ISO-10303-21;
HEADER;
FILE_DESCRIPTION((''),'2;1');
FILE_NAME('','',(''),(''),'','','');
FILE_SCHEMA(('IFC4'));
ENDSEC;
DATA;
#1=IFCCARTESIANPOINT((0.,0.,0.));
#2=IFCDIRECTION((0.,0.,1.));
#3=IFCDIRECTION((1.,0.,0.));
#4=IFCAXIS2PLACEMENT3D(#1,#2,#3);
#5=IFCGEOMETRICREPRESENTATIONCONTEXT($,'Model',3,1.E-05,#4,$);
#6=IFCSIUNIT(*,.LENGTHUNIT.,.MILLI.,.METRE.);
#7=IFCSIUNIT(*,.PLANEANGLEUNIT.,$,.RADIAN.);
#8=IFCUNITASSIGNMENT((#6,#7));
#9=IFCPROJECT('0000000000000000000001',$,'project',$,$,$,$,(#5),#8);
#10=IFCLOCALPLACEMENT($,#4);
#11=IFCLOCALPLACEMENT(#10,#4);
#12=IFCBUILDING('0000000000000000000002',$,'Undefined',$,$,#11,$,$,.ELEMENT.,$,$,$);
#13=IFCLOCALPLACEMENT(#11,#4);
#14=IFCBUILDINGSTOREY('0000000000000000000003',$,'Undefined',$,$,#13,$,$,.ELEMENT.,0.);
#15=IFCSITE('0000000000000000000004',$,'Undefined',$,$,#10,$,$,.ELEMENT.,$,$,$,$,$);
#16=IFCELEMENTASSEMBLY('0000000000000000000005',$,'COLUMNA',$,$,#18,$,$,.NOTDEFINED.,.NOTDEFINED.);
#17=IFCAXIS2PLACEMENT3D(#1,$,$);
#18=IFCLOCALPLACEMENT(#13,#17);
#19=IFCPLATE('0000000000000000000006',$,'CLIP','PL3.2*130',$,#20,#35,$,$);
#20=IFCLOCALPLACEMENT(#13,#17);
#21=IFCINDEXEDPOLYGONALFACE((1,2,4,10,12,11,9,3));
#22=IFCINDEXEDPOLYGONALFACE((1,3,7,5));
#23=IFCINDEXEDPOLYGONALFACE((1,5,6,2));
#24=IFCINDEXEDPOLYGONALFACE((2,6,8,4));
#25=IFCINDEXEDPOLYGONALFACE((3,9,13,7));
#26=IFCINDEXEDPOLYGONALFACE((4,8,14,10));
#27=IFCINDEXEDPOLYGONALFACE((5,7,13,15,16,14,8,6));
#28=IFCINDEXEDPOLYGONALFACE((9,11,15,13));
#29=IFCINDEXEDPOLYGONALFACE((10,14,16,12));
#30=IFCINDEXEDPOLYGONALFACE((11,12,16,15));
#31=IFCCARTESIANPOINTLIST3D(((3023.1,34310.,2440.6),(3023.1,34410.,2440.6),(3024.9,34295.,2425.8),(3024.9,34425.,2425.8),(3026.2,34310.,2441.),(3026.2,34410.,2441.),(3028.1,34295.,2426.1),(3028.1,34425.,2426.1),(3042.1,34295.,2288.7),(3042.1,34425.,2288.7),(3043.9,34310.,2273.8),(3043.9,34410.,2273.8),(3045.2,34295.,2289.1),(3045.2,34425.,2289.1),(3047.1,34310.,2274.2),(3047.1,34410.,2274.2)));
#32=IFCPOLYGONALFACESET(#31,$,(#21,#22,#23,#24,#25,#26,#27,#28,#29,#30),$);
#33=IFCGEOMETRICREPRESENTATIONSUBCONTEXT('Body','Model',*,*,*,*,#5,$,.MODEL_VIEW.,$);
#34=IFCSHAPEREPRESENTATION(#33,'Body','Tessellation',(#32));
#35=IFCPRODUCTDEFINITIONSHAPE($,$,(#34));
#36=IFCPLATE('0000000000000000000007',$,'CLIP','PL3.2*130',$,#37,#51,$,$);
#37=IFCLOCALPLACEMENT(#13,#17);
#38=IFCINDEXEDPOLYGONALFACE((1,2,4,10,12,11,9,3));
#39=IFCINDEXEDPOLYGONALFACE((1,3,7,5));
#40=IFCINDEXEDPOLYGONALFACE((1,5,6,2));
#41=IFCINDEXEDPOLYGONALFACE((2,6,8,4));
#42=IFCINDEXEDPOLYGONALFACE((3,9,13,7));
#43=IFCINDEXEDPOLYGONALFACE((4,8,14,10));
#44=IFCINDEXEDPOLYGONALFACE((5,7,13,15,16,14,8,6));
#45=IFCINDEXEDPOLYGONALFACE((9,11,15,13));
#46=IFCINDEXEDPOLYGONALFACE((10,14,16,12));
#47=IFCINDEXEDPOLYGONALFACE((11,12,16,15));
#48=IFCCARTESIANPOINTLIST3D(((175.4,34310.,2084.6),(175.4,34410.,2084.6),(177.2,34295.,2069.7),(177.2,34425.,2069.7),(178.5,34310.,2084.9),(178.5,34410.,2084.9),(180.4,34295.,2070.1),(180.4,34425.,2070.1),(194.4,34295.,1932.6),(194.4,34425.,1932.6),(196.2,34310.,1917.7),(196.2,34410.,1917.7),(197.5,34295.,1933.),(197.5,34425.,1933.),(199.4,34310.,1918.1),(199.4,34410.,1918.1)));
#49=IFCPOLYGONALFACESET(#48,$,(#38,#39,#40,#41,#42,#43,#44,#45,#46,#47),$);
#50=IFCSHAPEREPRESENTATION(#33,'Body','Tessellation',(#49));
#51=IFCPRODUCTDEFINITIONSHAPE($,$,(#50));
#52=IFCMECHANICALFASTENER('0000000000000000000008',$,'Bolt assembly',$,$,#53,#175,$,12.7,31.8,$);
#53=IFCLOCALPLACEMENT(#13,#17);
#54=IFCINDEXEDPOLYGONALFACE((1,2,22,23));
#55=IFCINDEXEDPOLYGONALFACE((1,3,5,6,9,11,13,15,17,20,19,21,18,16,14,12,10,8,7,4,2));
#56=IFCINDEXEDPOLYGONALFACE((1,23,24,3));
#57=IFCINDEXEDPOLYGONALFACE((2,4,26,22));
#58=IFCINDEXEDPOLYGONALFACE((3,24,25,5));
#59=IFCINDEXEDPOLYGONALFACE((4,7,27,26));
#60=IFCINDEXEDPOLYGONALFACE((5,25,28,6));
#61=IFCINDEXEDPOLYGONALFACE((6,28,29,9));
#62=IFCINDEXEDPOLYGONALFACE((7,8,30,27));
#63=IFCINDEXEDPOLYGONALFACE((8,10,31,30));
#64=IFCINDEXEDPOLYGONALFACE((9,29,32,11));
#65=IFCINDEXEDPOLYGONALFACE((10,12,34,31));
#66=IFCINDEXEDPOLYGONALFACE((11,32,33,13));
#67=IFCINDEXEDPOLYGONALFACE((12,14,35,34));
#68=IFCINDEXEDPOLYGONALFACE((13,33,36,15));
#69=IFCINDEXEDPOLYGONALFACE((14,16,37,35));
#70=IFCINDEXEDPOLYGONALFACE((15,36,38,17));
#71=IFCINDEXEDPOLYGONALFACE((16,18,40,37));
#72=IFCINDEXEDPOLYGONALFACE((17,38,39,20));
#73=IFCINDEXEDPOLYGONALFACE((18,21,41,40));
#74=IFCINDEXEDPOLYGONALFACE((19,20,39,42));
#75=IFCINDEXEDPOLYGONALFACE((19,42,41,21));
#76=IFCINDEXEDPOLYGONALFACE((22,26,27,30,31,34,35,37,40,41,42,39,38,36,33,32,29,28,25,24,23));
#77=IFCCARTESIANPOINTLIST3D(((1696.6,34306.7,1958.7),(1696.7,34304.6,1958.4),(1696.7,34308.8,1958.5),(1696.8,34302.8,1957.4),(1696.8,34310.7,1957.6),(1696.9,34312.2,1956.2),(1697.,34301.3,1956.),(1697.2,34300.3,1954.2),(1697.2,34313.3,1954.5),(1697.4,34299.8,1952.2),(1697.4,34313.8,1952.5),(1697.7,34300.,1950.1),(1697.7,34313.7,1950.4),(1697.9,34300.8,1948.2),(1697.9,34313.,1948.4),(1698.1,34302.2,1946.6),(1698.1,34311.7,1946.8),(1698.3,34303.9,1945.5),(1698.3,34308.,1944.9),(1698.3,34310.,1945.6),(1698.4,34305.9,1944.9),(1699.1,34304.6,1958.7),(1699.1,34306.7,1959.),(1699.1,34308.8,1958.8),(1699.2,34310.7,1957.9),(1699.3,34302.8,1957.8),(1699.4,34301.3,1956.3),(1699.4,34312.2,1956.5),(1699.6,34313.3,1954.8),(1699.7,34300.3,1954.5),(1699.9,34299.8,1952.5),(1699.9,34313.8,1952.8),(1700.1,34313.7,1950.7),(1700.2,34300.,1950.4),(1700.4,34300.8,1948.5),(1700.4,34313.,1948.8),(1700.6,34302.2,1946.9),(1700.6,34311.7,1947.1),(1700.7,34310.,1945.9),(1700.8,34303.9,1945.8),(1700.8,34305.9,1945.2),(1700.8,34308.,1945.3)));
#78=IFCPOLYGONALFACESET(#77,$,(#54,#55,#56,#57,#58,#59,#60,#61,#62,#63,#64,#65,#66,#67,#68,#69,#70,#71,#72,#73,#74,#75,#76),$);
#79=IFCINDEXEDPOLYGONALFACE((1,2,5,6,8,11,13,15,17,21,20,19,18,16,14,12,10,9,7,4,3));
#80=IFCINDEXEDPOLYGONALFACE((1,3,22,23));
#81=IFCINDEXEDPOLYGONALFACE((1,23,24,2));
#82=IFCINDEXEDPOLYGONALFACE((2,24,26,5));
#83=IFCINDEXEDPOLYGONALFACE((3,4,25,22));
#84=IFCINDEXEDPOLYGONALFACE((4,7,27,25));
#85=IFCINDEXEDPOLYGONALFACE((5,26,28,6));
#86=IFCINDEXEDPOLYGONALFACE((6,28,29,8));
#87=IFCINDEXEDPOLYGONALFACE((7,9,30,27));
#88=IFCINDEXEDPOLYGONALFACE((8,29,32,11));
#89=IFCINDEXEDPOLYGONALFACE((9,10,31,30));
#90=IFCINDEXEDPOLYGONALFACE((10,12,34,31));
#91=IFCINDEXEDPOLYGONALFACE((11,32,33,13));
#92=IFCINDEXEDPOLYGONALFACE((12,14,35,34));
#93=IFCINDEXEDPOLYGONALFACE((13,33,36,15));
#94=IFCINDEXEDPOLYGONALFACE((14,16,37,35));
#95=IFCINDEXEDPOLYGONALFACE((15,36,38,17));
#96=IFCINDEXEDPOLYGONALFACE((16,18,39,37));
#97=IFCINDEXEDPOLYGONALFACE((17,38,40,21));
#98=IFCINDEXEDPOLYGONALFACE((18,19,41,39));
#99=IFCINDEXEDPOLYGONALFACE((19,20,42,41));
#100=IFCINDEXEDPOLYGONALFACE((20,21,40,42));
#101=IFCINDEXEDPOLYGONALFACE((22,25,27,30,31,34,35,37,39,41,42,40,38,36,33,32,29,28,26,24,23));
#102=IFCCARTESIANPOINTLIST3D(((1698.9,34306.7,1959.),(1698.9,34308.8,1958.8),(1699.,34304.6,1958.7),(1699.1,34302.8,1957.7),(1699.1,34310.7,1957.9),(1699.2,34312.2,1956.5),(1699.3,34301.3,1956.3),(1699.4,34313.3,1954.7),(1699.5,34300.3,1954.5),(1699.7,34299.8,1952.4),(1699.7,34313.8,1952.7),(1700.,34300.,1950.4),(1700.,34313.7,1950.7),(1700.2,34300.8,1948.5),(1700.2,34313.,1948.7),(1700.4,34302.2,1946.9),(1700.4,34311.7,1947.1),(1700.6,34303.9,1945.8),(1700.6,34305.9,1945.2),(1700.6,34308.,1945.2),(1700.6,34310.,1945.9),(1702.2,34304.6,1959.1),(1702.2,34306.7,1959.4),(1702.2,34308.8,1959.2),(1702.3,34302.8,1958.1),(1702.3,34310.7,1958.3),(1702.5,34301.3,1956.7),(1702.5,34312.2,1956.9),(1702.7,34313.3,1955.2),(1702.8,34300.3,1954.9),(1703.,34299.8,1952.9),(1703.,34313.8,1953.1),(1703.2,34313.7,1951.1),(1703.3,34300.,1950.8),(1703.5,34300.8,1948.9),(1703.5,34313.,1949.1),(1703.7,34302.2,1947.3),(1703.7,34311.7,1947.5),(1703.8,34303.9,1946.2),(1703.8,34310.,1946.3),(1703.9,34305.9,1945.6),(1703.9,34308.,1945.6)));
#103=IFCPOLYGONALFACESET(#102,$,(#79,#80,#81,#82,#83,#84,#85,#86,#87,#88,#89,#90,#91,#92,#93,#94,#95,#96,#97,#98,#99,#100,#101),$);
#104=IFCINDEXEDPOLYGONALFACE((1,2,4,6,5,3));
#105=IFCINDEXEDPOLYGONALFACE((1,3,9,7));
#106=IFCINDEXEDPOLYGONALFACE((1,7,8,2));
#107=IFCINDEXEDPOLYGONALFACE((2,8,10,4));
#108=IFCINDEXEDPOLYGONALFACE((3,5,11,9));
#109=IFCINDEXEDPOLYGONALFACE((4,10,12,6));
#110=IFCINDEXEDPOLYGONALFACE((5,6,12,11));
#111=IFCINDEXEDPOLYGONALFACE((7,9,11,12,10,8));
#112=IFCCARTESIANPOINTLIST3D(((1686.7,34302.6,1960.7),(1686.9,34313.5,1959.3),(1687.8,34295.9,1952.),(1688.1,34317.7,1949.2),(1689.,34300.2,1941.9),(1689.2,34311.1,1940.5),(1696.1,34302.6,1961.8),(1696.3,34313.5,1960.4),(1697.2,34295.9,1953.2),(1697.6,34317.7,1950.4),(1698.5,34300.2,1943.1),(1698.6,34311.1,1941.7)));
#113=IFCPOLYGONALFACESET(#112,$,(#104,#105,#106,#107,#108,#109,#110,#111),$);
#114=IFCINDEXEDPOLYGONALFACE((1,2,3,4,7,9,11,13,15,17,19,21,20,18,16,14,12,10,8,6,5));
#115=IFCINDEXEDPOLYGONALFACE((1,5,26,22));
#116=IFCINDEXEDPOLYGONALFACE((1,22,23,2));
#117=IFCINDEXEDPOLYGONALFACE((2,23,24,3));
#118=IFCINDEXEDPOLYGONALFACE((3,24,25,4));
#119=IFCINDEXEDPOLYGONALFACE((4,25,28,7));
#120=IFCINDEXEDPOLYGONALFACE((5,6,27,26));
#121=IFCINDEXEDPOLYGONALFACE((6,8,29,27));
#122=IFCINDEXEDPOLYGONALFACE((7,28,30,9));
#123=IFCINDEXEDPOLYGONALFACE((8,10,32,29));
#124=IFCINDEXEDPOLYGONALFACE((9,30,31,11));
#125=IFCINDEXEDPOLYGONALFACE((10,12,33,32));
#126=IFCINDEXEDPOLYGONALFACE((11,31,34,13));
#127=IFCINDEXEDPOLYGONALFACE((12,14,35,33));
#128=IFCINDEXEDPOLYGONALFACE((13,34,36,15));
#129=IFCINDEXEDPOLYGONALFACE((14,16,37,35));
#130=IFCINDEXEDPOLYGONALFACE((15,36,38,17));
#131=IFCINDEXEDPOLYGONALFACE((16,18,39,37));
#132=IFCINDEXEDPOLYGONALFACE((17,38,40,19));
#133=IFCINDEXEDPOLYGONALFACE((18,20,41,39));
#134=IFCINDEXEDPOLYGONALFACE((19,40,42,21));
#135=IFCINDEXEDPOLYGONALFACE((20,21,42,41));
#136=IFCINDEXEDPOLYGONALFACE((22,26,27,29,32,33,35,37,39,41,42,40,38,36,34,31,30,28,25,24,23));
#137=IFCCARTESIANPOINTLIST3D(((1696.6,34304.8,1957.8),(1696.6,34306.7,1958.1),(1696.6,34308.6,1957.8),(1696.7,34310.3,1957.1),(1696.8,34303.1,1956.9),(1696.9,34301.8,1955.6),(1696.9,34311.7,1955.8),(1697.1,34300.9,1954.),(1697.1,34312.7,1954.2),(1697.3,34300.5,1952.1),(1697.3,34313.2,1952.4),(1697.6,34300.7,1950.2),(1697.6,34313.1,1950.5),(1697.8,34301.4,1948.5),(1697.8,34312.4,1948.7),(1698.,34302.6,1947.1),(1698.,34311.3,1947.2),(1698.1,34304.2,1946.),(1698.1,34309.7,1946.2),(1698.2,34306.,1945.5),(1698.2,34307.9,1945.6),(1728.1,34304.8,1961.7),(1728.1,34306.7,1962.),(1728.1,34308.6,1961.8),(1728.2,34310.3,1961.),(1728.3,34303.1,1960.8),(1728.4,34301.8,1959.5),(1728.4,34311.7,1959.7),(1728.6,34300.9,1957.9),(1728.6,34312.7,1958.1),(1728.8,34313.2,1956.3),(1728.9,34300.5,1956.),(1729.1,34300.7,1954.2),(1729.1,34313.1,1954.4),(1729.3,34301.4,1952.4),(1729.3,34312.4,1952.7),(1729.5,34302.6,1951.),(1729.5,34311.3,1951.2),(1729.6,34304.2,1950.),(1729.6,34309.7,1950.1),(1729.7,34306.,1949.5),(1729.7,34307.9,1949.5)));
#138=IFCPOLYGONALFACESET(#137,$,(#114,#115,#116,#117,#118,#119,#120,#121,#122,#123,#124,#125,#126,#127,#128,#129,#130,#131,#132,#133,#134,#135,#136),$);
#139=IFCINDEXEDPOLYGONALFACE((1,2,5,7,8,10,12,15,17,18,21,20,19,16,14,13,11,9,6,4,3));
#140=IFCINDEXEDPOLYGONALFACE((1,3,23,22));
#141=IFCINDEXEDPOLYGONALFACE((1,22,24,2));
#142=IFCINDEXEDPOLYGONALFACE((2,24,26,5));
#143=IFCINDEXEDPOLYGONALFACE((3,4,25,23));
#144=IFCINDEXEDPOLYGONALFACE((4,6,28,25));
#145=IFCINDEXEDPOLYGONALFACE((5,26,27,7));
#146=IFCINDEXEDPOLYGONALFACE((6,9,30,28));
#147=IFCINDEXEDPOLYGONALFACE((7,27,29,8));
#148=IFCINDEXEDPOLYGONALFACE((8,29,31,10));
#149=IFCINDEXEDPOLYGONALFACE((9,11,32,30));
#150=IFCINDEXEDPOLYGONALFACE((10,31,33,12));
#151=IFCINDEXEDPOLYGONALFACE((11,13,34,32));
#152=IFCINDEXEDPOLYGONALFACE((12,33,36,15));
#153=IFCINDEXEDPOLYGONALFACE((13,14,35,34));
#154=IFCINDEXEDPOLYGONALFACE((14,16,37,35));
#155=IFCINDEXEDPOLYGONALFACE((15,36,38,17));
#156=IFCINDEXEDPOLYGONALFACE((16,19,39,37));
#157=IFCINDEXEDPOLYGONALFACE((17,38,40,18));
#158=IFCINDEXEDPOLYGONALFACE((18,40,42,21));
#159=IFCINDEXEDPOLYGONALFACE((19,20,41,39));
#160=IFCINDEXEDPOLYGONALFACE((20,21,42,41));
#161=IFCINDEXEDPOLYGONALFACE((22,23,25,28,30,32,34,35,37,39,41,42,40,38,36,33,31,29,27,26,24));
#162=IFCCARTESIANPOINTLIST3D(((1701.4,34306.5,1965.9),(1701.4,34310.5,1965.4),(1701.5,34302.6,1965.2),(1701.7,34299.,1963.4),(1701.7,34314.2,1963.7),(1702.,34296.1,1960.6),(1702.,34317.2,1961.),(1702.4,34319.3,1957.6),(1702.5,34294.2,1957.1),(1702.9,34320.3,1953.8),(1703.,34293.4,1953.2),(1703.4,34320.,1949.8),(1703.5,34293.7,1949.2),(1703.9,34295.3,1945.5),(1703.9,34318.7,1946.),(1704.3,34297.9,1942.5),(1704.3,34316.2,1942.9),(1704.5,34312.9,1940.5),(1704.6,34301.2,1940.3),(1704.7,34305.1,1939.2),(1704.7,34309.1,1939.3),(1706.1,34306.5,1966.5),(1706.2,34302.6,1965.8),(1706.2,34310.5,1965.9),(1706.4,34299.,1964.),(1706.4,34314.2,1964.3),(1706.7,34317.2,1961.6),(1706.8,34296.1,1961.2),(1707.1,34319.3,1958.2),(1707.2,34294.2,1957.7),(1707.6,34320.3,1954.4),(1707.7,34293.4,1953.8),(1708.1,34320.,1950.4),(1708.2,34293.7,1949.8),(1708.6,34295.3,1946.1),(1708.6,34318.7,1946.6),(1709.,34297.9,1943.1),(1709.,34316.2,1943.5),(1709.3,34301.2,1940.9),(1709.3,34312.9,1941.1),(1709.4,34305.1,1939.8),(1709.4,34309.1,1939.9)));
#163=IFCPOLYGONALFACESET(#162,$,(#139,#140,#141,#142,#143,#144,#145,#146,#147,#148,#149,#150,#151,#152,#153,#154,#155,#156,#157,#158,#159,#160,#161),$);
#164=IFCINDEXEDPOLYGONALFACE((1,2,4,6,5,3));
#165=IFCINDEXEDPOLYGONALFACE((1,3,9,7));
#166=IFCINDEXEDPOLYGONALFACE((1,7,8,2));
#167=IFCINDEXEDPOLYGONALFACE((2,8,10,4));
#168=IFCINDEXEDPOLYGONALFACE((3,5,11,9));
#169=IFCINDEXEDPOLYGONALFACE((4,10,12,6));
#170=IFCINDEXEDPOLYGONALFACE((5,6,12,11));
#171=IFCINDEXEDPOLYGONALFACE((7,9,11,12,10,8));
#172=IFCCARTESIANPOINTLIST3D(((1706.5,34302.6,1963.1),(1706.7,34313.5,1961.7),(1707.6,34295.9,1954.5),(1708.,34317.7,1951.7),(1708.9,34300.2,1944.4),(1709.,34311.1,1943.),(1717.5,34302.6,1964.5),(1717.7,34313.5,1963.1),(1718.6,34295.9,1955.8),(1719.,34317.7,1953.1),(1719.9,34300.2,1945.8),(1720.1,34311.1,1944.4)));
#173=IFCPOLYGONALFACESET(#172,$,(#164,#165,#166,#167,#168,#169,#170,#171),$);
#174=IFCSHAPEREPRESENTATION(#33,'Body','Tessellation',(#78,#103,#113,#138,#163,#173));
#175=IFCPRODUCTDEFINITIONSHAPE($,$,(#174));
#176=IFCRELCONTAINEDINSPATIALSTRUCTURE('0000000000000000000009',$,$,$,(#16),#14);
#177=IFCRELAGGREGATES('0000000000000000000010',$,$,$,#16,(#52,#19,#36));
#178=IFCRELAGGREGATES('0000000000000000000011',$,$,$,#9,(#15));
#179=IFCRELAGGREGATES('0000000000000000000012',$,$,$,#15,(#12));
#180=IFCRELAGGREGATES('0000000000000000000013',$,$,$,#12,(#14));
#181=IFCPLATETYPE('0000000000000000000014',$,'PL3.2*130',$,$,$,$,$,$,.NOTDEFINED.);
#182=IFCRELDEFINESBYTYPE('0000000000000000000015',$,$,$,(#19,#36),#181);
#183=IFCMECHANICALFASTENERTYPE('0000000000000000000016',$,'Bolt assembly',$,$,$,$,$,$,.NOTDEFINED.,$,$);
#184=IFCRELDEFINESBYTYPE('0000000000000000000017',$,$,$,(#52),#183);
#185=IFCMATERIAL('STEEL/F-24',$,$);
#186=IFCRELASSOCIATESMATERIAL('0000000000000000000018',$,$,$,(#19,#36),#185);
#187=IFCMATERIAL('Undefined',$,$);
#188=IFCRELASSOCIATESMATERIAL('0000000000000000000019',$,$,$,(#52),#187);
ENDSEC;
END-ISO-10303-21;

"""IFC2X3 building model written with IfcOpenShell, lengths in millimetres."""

from ifc_helpers import new_model, si_unit, frame, origin_with_axes, origin_2d_with_axis, place, context, subcontext, project, spatial, polyline, circle, outline, extrude, source, transform, mapped, material, type_object, element, aggregate, save


model = new_model("IFC2X3")

# Units and contexts
model_context = context("Model", 3, precision=1e-05, world=origin_with_axes())
body_context = subcontext(model_context, "Body", "Model", "MODEL_VIEW")
ifc_project = project(units=[si_unit("LENGTHUNIT", "METRE", prefix="MILLI"), si_unit("PLANEANGLEUNIT", "RADIAN")], contexts=[model_context])

# Site, building, storey
site_placement = place(None, origin_with_axes())
site = spatial("IfcSite", under=ifc_project, at=site_placement, Name="Undefined", CompositionType="ELEMENT")
building_placement = place(site_placement, origin_with_axes())
building = spatial("IfcBuilding", under=site, at=building_placement, Name="Undefined", CompositionType="ELEMENT")
storey_placement = place(building_placement, origin_with_axes())
storey = spatial("IfcBuildingStorey", under=building, at=storey_placement, Name="Undefined", CompositionType="ELEMENT", Elevation=0.0)

# Shared definitions
ifc_material_1 = material(Name="STEEL/F-24")

# Element assembly, plates, mechanical fastener
assembly_1_placement = place(storey_placement, origin_with_axes())
assembly_1 = element("IfcElementAssembly", 1, at=assembly_1_placement, inside=storey, Name="COLUMNA", AssemblyPlace="NOTDEFINED", PredefinedType="NOTDEFINED")
plate_type_1 = type_object("IfcPlateType", Name="PL3.2*130", PredefinedType="NOTDEFINED")
plate_1_placement = place(assembly_1_placement, frame((3024.6, 34295.0, 2440.8), z_axis=(-0.992271, 0.0, -0.124089), x_axis=(0.0, 1.0, 0.0)))
plate_1 = element("IfcPlate", 2, at=plate_1_placement, type_object=plate_type_1, material=ifc_material_1, Name="CLIP", Description="PL3.2*130", context=body_context, shape_type="SweptSolid", body=[
    extrude(outline(polyline([(0.0, 15.0), (15.0, 0.0), (115.0, 0.0), (130.0, 15.0), (130.0, 153.1), (115.0, 168.1), (15.0, 168.1), (0.0, 153.1), (0.0, 15.0)])), frame((0.0, 0.0, -1.6), z_axis=(0.0, 0.0, 1.0), x_axis=(1.0, 0.0, 0.0)), (0.0, 0.0, 1.0), 3.2),
])
plate_2_placement = place(assembly_1_placement, frame((176.9, 34295.0, 2084.7), z_axis=(-0.992275, 0.0, -0.124059), x_axis=(0.0, 1.0, 0.0)))
plate_2 = element("IfcPlate", 3, at=plate_2_placement, type_object=plate_type_1, material=ifc_material_1, Name="CLIP", Description="PL3.2*130", context=body_context, shape_type="SweptSolid", body=[
    extrude(outline(polyline([(0.0, 15.0), (15.0, 0.0), (115.0, 0.0), (130.0, 15.0), (130.0, 153.1), (115.0, 168.1), (15.0, 168.1), (0.0, 153.1), (0.0, 15.0)])), frame((0.0, 0.0, -1.6), z_axis=(0.0, 0.0, 1.0), x_axis=(1.0, 0.0, 0.0)), (0.0, 0.0, 1.0), 3.2),
])
ifc_material_2 = material(Name="Undefined")
mechanical_fastener_type = type_object("IfcMechanicalFastenerType", Name="Bolt assembly")
shared_shape_1 = source(origin_with_axes(), body_context, "Body", "SweptSolid", [
    extrude(circle(Radius=7.0, at=origin_2d_with_axis()), frame((0.0, -2.4, 0.0), z_axis=(0.0, 1.0, 0.0), x_axis=(1.0, 0.0, 0.0)), (0.0, 0.0, 1.0), 2.5),
    extrude(circle(Radius=7.0, at=origin_2d_with_axis()), frame((0.0, -0.1, 0.0), z_axis=(0.0, 1.0, 0.0), x_axis=(1.0, 0.0, 0.0)), (0.0, 0.0, 1.0), 3.3),
    extrude(outline(polyline([(9.5, -5.5), (9.5, 5.5), (0.0, 11.0), (-9.5, 5.5), (-9.5, -5.5), (0.0, -11.0), (9.5, -5.5)])), frame((0.0, -12.0, 0.0), z_axis=(0.0, 1.0, 0.0), x_axis=(1.0, 0.0, 0.0)), (0.0, 0.0, 1.0), 9.5),
    extrude(circle(Radius=6.3, at=origin_2d_with_axis()), frame((0.0, -2.5, 0.0), z_axis=(0.0, 1.0, 0.0), x_axis=(1.0, 0.0, 0.0)), (0.0, 0.0, 1.0), 31.8),
    extrude(circle(Radius=13.5, at=origin_2d_with_axis()), frame((0.0, 3.2, 0.0), z_axis=(0.0, 1.0, 0.0), x_axis=(1.0, 0.0, 0.0)), (0.0, 0.0, 1.0), 4.8),
    extrude(outline(polyline([(9.5, -5.5), (9.5, 5.5), (0.0, 11.0), (-9.5, 5.5), (-9.5, -5.5), (0.0, -11.0), (9.5, -5.5)])), frame((0.0, 8.0, 0.0), z_axis=(0.0, 1.0, 0.0), x_axis=(1.0, 0.0, 0.0)), (0.0, 0.0, 1.0), 11.1),
])
mechanical_fastener_1_placement = place(assembly_1_placement, frame((1699.9, 34306.8, 1952.1), z_axis=(-0.098611, 0.606774, 0.788734), x_axis=(-0.075276, -0.794875, 0.602086)))
mechanical_fastener_1 = element("IfcMechanicalFastener", 4, at=mechanical_fastener_1_placement, type_object=mechanical_fastener_type, material=ifc_material_2, Name="Bolt assembly", NominalDiameter=12.7, NominalLength=31.8, context=body_context, shape_type="MappedRepresentation", body=[
    mapped(shared_shape_1, transform((0.0, 0.0, 0.0))),
])
aggregate(assembly_1, [mechanical_fastener_1, plate_1, plate_2])

save(model, "model.ifc")
